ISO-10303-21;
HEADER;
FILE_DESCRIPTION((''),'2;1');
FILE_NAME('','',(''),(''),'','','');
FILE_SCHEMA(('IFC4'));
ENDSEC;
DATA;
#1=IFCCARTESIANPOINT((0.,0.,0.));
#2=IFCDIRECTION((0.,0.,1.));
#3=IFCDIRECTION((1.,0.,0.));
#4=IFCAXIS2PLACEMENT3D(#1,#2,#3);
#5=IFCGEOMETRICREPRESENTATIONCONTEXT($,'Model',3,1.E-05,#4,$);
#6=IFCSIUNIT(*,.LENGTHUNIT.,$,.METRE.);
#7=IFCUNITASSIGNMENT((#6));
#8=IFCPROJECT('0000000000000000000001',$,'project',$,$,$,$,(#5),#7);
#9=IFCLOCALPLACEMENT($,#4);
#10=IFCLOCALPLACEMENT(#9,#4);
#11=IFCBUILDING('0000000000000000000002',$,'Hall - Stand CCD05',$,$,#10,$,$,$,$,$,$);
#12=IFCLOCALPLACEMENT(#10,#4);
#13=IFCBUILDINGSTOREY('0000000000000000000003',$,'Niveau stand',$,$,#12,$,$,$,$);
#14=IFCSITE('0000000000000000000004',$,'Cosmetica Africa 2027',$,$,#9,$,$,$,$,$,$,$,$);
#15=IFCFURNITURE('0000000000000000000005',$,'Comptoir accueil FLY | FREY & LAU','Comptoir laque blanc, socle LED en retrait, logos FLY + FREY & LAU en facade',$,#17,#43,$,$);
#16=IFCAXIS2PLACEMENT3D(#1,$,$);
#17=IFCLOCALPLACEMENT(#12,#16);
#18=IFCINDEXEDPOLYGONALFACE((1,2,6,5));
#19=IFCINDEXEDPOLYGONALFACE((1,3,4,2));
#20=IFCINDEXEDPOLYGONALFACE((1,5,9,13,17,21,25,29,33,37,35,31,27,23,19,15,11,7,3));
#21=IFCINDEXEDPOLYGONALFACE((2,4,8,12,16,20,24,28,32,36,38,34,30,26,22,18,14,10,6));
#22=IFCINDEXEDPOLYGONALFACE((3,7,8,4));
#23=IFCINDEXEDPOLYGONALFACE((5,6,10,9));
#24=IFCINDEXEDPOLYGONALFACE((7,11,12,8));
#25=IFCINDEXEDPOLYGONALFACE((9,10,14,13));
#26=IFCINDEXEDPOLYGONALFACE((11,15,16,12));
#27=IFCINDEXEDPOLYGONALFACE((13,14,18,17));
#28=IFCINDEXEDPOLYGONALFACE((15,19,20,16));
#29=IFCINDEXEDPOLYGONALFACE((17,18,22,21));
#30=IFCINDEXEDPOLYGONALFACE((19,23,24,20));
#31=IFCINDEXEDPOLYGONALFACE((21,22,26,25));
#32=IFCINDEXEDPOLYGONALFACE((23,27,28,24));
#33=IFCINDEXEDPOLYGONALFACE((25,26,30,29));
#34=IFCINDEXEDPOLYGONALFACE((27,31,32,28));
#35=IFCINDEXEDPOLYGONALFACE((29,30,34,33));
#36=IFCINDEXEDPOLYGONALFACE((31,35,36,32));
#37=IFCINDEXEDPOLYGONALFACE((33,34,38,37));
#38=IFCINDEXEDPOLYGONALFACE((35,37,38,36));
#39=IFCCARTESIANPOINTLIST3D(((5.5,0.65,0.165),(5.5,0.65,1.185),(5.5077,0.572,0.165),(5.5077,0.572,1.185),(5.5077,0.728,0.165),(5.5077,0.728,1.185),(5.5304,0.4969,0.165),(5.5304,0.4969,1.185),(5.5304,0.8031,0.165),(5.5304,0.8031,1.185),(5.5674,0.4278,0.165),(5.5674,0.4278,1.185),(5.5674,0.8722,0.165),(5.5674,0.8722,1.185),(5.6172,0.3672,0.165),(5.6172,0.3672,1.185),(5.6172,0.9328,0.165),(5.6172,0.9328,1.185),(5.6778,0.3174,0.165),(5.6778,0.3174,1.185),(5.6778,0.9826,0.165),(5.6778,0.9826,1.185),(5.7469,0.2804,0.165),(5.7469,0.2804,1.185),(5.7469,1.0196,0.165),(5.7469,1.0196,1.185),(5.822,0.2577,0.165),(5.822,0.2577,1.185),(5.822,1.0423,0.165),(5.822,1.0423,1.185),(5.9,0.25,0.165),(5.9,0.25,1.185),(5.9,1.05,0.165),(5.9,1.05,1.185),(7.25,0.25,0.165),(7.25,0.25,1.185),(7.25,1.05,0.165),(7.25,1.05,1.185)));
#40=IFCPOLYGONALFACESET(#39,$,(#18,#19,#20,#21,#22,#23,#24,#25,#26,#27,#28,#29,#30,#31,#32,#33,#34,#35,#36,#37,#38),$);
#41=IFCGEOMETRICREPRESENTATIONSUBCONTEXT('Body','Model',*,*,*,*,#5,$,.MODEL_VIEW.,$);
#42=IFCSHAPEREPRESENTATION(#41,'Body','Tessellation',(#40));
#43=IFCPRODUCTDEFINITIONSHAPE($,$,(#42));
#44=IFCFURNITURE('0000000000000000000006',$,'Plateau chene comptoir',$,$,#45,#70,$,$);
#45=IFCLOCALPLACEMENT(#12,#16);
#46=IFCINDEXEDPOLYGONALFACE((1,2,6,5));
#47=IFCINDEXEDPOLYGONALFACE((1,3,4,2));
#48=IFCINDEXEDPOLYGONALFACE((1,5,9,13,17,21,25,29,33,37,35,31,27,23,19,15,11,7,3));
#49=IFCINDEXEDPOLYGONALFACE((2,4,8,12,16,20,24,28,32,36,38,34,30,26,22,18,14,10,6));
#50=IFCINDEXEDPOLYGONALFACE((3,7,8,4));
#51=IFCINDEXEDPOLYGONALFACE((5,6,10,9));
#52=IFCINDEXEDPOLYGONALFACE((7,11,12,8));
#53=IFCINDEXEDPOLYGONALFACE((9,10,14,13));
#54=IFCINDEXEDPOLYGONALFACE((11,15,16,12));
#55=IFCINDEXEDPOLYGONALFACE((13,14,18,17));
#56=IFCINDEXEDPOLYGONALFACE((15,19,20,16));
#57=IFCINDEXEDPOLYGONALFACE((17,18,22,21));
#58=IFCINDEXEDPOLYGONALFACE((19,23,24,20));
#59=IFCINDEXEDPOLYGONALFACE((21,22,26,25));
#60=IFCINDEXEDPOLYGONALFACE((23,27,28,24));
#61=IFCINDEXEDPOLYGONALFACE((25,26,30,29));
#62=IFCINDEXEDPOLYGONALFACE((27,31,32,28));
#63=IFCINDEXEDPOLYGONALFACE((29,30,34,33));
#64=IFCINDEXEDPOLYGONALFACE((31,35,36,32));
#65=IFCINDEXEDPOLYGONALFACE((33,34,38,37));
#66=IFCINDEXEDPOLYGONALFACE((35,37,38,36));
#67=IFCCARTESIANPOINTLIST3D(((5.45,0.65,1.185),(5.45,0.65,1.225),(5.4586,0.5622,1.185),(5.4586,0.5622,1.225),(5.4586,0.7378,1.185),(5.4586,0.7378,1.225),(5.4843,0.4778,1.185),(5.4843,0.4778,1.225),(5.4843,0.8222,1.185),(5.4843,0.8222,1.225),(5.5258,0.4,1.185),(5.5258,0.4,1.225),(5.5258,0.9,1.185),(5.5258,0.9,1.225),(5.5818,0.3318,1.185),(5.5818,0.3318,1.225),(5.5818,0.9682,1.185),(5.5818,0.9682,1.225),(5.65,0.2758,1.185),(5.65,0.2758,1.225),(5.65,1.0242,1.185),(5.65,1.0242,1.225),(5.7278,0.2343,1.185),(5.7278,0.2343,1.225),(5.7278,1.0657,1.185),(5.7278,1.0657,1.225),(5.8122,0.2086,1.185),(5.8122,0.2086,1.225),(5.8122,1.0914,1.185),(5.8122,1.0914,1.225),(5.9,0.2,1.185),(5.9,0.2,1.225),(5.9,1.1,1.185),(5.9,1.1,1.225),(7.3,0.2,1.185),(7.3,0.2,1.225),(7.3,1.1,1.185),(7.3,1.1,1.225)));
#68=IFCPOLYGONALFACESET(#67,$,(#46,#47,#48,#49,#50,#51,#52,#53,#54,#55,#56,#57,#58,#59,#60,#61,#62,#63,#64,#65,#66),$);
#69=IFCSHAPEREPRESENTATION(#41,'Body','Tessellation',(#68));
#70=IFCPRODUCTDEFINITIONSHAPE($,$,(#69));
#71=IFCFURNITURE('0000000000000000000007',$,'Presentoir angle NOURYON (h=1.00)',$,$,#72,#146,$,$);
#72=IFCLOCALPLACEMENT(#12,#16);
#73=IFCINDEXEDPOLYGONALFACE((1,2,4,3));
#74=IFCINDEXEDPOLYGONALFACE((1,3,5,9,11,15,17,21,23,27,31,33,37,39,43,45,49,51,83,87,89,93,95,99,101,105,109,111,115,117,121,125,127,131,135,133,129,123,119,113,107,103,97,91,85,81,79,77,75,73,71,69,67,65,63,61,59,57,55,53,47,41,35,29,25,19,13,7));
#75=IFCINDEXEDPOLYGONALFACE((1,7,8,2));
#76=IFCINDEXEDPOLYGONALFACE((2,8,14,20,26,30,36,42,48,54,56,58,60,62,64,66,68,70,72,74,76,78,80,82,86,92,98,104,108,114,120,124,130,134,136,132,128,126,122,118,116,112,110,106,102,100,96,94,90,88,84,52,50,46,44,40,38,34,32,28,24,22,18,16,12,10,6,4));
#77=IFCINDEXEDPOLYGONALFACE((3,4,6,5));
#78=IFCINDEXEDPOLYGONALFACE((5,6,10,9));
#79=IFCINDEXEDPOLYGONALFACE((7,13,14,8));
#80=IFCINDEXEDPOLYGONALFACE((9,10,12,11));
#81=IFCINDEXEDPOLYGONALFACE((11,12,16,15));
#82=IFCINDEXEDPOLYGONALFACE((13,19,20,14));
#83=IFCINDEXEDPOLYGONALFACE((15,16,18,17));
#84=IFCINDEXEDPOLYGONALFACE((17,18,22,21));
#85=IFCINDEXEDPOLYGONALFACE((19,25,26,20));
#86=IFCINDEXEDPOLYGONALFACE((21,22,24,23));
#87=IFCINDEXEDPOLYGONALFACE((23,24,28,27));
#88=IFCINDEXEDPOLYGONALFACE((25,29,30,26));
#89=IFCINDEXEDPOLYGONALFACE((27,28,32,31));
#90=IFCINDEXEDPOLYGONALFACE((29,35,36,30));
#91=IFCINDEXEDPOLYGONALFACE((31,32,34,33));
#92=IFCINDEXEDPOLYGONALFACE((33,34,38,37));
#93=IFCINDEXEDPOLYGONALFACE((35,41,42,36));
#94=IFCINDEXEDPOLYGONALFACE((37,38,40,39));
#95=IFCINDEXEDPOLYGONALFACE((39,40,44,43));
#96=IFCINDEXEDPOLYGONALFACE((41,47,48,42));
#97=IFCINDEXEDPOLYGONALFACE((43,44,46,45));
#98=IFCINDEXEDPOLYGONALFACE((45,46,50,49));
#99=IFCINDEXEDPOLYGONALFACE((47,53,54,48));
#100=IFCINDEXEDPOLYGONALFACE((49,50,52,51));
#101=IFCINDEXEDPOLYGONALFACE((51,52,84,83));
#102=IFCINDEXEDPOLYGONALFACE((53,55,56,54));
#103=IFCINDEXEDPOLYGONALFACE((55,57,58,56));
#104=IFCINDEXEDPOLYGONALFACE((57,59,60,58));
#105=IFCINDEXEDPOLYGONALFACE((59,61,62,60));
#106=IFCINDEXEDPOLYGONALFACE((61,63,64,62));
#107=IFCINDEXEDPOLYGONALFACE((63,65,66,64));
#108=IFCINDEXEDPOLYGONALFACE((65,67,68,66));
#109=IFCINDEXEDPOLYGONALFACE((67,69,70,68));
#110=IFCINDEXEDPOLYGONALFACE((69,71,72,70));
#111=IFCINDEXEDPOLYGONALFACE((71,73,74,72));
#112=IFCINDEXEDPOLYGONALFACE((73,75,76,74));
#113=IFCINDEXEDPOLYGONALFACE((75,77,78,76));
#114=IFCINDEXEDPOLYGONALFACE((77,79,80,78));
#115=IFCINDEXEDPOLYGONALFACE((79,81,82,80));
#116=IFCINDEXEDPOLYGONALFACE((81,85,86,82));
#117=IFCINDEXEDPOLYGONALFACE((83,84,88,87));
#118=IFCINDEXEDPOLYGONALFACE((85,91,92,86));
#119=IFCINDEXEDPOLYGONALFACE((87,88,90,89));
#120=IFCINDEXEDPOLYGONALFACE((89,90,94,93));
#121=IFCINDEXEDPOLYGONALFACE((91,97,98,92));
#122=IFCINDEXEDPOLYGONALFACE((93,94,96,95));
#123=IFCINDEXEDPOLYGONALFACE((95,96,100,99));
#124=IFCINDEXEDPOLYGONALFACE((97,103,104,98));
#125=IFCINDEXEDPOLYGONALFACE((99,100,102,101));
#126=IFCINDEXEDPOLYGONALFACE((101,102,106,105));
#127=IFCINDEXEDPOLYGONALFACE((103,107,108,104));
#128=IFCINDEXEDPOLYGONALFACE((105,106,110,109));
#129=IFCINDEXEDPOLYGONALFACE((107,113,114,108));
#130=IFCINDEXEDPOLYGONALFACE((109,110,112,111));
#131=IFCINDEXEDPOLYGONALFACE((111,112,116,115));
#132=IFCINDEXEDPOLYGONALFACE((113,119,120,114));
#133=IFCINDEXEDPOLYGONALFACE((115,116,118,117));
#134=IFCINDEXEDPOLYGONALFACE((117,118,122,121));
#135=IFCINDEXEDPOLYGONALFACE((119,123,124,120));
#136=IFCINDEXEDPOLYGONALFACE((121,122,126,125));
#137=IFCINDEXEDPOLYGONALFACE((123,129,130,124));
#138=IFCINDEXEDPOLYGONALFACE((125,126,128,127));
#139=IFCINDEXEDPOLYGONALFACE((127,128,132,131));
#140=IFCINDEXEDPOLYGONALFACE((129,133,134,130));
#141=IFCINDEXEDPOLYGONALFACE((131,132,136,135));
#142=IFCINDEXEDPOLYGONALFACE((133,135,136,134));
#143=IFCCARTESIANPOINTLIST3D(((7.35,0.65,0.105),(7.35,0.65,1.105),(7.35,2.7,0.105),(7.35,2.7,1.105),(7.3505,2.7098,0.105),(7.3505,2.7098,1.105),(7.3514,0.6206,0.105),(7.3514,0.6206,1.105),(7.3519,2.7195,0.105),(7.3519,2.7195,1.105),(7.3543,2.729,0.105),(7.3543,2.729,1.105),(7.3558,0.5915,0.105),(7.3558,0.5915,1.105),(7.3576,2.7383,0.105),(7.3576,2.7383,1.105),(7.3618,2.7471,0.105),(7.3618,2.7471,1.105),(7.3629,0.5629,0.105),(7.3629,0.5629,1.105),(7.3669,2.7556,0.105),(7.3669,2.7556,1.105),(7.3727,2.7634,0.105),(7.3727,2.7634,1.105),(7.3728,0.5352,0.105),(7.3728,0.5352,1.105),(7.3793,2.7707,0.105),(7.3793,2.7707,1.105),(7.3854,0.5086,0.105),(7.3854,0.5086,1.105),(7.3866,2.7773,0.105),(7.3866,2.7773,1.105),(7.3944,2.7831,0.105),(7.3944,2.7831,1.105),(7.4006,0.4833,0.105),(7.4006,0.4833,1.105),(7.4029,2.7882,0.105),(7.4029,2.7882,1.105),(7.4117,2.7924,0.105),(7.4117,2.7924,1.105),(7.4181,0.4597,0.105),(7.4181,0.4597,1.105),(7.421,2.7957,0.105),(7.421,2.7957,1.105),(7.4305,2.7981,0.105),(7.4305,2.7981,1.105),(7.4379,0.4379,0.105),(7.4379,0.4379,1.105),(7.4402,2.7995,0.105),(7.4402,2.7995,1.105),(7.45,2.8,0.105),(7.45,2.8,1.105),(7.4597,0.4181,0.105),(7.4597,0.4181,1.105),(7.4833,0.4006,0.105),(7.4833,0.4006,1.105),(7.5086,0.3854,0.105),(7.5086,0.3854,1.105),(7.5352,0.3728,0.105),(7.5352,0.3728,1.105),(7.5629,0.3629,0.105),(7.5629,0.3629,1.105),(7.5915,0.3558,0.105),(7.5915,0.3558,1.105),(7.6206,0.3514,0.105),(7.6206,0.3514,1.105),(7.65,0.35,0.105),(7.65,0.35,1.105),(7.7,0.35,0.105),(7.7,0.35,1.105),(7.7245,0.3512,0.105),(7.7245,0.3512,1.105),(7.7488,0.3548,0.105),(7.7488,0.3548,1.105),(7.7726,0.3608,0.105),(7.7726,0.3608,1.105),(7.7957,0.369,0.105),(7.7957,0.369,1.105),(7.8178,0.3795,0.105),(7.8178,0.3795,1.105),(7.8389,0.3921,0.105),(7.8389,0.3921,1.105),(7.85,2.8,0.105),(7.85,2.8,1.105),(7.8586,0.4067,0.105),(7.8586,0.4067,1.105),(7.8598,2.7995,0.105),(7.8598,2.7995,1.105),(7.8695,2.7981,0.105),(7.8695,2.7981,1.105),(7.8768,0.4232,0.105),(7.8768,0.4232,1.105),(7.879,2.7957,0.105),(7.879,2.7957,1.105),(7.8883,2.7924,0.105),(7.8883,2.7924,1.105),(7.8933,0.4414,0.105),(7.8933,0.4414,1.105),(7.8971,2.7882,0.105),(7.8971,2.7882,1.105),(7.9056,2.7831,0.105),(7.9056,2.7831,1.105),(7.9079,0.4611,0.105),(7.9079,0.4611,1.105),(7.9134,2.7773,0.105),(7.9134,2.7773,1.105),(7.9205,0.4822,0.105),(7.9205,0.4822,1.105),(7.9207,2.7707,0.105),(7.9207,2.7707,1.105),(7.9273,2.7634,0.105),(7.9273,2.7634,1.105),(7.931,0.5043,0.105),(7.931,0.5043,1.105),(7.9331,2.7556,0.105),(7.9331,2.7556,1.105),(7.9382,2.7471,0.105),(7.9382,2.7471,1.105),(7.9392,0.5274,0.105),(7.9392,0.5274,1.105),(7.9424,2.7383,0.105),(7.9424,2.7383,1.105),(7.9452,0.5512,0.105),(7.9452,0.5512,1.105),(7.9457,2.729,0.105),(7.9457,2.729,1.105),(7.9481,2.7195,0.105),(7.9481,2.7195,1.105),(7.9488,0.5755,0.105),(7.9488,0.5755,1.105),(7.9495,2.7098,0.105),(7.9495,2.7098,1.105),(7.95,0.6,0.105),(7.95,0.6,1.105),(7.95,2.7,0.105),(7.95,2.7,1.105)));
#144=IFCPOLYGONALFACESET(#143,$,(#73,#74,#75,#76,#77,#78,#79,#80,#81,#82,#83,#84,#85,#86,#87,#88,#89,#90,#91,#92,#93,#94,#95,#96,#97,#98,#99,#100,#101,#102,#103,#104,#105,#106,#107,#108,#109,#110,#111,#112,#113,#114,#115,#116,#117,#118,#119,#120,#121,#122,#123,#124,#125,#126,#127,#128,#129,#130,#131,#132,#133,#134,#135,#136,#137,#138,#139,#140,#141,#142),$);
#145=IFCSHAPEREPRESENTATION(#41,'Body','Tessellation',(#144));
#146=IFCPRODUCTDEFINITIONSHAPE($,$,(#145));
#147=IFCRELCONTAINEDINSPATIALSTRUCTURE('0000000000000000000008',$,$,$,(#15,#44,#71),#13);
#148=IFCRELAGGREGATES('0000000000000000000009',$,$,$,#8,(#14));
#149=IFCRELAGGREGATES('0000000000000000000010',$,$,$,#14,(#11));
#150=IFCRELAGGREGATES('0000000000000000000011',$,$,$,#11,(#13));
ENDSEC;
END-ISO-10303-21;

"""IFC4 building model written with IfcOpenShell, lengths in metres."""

from ifc_helpers import new_model, si_unit, frame, origin_with_axes, place, context, subcontext, project, spatial, polyline, outline, extrude, element, save


model = new_model("IFC4")

# Units and contexts
model_context = context("Model", 3, precision=1e-05, world=origin_with_axes())
body_context = subcontext(model_context, "Body", "Model", "MODEL_VIEW")
ifc_project = project(units=[si_unit("LENGTHUNIT", "METRE")], contexts=[model_context])

# Site, building, storey
site_placement = place(None, origin_with_axes())
site = spatial("IfcSite", under=ifc_project, at=site_placement, Name="Cosmetica Africa 2027")
building_placement = place(site_placement, origin_with_axes())
building = spatial("IfcBuilding", under=site, at=building_placement, Name="Hall - Stand CCD05")
storey_placement = place(building_placement, origin_with_axes())
storey = spatial("IfcBuildingStorey", under=building, at=storey_placement, Name="Niveau stand")

# Furniture
furniture_1_placement = place(storey_placement, origin_with_axes())
element("IfcFurniture", 1, at=furniture_1_placement, inside=storey, Name="Comptoir accueil FLY | FREY & LAU", Description="Comptoir laque blanc, socle LED en retrait, logos FLY + FREY & LAU en facade", context=body_context, shape_type="SweptSolid", body=[
    extrude(outline(polyline([(5.9, 0.25), (7.25, 0.25), (7.25, 1.05), (5.9, 1.05), (5.822, 1.0423), (5.7469, 1.0196), (5.6778, 0.9826), (5.6172, 0.9328), (5.5674, 0.8722), (5.5304, 0.8031), (5.5077, 0.728), (5.5, 0.65), (5.5077, 0.572), (5.5304, 0.4969), (5.5674, 0.4278), (5.6172, 0.3672), (5.6778, 0.3174), (5.7469, 0.2804), (5.822, 0.2577), (5.9, 0.25)])), frame((0.0, 0.0, 0.165)), (0.0, 0.0, 1.0), 1.02),
])
furniture_2_placement = place(storey_placement, origin_with_axes())
element("IfcFurniture", 2, at=furniture_2_placement, inside=storey, Name="Plateau chene comptoir", context=body_context, shape_type="SweptSolid", body=[
    extrude(outline(polyline([(5.9, 0.2), (7.3, 0.2), (7.3, 1.1), (5.9, 1.1), (5.8122, 1.0914), (5.7278, 1.0657), (5.65, 1.0242), (5.5818, 0.9682), (5.5258, 0.9), (5.4843, 0.8222), (5.4586, 0.7378), (5.45, 0.65), (5.4586, 0.5622), (5.4843, 0.4778), (5.5258, 0.4), (5.5818, 0.3318), (5.65, 0.2758), (5.7278, 0.2343), (5.8122, 0.2086), (5.9, 0.2)])), frame((0.0, 0.0, 1.185)), (0.0, 0.0, 1.0), 0.04),
])
furniture_3_placement = place(storey_placement, origin_with_axes())
element("IfcFurniture", 3, at=furniture_3_placement, inside=storey, Name="Presentoir angle NOURYON (h=1.00)", context=body_context, shape_type="SweptSolid", body=[
    extrude(outline(polyline([(7.35, 0.65), (7.3514, 0.6206), (7.3558, 0.5915), (7.3629, 0.5629), (7.3728, 0.5352), (7.3854, 0.5086), (7.4006, 0.4833), (7.4181, 0.4597), (7.4379, 0.4379), (7.4597, 0.4181), (7.4833, 0.4006), (7.5086, 0.3854), (7.5352, 0.3728), (7.5629, 0.3629), (7.5915, 0.3558), (7.6206, 0.3514), (7.65, 0.35), (7.7, 0.35), (7.7245, 0.3512), (7.7488, 0.3548), (7.7726, 0.3608), (7.7957, 0.369), (7.8178, 0.3795), (7.8389, 0.3921), (7.8586, 0.4067), (7.8768, 0.4232), (7.8933, 0.4414), (7.9079, 0.4611), (7.9205, 0.4822), (7.931, 0.5043), (7.9392, 0.5274), (7.9452, 0.5512), (7.9488, 0.5755), (7.95, 0.6), (7.95, 2.7), (7.9495, 2.7098), (7.9481, 2.7195), (7.9457, 2.729), (7.9424, 2.7383), (7.9382, 2.7471), (7.9331, 2.7556), (7.9273, 2.7634), (7.9207, 2.7707), (7.9134, 2.7773), (7.9056, 2.7831), (7.8971, 2.7882), (7.8883, 2.7924), (7.879, 2.7957), (7.8695, 2.7981), (7.8598, 2.7995), (7.85, 2.8), (7.45, 2.8), (7.4402, 2.7995), (7.4305, 2.7981), (7.421, 2.7957), (7.4117, 2.7924), (7.4029, 2.7882), (7.3944, 2.7831), (7.3866, 2.7773), (7.3793, 2.7707), (7.3727, 2.7634), (7.3669, 2.7556), (7.3618, 2.7471), (7.3576, 2.7383), (7.3543, 2.729), (7.3519, 2.7195), (7.3505, 2.7098), (7.35, 2.7), (7.35, 0.65)])), frame((0.0, 0.0, 0.105)), (0.0, 0.0, 1.0), 1.0),
])

save(model, "model.ifc")
